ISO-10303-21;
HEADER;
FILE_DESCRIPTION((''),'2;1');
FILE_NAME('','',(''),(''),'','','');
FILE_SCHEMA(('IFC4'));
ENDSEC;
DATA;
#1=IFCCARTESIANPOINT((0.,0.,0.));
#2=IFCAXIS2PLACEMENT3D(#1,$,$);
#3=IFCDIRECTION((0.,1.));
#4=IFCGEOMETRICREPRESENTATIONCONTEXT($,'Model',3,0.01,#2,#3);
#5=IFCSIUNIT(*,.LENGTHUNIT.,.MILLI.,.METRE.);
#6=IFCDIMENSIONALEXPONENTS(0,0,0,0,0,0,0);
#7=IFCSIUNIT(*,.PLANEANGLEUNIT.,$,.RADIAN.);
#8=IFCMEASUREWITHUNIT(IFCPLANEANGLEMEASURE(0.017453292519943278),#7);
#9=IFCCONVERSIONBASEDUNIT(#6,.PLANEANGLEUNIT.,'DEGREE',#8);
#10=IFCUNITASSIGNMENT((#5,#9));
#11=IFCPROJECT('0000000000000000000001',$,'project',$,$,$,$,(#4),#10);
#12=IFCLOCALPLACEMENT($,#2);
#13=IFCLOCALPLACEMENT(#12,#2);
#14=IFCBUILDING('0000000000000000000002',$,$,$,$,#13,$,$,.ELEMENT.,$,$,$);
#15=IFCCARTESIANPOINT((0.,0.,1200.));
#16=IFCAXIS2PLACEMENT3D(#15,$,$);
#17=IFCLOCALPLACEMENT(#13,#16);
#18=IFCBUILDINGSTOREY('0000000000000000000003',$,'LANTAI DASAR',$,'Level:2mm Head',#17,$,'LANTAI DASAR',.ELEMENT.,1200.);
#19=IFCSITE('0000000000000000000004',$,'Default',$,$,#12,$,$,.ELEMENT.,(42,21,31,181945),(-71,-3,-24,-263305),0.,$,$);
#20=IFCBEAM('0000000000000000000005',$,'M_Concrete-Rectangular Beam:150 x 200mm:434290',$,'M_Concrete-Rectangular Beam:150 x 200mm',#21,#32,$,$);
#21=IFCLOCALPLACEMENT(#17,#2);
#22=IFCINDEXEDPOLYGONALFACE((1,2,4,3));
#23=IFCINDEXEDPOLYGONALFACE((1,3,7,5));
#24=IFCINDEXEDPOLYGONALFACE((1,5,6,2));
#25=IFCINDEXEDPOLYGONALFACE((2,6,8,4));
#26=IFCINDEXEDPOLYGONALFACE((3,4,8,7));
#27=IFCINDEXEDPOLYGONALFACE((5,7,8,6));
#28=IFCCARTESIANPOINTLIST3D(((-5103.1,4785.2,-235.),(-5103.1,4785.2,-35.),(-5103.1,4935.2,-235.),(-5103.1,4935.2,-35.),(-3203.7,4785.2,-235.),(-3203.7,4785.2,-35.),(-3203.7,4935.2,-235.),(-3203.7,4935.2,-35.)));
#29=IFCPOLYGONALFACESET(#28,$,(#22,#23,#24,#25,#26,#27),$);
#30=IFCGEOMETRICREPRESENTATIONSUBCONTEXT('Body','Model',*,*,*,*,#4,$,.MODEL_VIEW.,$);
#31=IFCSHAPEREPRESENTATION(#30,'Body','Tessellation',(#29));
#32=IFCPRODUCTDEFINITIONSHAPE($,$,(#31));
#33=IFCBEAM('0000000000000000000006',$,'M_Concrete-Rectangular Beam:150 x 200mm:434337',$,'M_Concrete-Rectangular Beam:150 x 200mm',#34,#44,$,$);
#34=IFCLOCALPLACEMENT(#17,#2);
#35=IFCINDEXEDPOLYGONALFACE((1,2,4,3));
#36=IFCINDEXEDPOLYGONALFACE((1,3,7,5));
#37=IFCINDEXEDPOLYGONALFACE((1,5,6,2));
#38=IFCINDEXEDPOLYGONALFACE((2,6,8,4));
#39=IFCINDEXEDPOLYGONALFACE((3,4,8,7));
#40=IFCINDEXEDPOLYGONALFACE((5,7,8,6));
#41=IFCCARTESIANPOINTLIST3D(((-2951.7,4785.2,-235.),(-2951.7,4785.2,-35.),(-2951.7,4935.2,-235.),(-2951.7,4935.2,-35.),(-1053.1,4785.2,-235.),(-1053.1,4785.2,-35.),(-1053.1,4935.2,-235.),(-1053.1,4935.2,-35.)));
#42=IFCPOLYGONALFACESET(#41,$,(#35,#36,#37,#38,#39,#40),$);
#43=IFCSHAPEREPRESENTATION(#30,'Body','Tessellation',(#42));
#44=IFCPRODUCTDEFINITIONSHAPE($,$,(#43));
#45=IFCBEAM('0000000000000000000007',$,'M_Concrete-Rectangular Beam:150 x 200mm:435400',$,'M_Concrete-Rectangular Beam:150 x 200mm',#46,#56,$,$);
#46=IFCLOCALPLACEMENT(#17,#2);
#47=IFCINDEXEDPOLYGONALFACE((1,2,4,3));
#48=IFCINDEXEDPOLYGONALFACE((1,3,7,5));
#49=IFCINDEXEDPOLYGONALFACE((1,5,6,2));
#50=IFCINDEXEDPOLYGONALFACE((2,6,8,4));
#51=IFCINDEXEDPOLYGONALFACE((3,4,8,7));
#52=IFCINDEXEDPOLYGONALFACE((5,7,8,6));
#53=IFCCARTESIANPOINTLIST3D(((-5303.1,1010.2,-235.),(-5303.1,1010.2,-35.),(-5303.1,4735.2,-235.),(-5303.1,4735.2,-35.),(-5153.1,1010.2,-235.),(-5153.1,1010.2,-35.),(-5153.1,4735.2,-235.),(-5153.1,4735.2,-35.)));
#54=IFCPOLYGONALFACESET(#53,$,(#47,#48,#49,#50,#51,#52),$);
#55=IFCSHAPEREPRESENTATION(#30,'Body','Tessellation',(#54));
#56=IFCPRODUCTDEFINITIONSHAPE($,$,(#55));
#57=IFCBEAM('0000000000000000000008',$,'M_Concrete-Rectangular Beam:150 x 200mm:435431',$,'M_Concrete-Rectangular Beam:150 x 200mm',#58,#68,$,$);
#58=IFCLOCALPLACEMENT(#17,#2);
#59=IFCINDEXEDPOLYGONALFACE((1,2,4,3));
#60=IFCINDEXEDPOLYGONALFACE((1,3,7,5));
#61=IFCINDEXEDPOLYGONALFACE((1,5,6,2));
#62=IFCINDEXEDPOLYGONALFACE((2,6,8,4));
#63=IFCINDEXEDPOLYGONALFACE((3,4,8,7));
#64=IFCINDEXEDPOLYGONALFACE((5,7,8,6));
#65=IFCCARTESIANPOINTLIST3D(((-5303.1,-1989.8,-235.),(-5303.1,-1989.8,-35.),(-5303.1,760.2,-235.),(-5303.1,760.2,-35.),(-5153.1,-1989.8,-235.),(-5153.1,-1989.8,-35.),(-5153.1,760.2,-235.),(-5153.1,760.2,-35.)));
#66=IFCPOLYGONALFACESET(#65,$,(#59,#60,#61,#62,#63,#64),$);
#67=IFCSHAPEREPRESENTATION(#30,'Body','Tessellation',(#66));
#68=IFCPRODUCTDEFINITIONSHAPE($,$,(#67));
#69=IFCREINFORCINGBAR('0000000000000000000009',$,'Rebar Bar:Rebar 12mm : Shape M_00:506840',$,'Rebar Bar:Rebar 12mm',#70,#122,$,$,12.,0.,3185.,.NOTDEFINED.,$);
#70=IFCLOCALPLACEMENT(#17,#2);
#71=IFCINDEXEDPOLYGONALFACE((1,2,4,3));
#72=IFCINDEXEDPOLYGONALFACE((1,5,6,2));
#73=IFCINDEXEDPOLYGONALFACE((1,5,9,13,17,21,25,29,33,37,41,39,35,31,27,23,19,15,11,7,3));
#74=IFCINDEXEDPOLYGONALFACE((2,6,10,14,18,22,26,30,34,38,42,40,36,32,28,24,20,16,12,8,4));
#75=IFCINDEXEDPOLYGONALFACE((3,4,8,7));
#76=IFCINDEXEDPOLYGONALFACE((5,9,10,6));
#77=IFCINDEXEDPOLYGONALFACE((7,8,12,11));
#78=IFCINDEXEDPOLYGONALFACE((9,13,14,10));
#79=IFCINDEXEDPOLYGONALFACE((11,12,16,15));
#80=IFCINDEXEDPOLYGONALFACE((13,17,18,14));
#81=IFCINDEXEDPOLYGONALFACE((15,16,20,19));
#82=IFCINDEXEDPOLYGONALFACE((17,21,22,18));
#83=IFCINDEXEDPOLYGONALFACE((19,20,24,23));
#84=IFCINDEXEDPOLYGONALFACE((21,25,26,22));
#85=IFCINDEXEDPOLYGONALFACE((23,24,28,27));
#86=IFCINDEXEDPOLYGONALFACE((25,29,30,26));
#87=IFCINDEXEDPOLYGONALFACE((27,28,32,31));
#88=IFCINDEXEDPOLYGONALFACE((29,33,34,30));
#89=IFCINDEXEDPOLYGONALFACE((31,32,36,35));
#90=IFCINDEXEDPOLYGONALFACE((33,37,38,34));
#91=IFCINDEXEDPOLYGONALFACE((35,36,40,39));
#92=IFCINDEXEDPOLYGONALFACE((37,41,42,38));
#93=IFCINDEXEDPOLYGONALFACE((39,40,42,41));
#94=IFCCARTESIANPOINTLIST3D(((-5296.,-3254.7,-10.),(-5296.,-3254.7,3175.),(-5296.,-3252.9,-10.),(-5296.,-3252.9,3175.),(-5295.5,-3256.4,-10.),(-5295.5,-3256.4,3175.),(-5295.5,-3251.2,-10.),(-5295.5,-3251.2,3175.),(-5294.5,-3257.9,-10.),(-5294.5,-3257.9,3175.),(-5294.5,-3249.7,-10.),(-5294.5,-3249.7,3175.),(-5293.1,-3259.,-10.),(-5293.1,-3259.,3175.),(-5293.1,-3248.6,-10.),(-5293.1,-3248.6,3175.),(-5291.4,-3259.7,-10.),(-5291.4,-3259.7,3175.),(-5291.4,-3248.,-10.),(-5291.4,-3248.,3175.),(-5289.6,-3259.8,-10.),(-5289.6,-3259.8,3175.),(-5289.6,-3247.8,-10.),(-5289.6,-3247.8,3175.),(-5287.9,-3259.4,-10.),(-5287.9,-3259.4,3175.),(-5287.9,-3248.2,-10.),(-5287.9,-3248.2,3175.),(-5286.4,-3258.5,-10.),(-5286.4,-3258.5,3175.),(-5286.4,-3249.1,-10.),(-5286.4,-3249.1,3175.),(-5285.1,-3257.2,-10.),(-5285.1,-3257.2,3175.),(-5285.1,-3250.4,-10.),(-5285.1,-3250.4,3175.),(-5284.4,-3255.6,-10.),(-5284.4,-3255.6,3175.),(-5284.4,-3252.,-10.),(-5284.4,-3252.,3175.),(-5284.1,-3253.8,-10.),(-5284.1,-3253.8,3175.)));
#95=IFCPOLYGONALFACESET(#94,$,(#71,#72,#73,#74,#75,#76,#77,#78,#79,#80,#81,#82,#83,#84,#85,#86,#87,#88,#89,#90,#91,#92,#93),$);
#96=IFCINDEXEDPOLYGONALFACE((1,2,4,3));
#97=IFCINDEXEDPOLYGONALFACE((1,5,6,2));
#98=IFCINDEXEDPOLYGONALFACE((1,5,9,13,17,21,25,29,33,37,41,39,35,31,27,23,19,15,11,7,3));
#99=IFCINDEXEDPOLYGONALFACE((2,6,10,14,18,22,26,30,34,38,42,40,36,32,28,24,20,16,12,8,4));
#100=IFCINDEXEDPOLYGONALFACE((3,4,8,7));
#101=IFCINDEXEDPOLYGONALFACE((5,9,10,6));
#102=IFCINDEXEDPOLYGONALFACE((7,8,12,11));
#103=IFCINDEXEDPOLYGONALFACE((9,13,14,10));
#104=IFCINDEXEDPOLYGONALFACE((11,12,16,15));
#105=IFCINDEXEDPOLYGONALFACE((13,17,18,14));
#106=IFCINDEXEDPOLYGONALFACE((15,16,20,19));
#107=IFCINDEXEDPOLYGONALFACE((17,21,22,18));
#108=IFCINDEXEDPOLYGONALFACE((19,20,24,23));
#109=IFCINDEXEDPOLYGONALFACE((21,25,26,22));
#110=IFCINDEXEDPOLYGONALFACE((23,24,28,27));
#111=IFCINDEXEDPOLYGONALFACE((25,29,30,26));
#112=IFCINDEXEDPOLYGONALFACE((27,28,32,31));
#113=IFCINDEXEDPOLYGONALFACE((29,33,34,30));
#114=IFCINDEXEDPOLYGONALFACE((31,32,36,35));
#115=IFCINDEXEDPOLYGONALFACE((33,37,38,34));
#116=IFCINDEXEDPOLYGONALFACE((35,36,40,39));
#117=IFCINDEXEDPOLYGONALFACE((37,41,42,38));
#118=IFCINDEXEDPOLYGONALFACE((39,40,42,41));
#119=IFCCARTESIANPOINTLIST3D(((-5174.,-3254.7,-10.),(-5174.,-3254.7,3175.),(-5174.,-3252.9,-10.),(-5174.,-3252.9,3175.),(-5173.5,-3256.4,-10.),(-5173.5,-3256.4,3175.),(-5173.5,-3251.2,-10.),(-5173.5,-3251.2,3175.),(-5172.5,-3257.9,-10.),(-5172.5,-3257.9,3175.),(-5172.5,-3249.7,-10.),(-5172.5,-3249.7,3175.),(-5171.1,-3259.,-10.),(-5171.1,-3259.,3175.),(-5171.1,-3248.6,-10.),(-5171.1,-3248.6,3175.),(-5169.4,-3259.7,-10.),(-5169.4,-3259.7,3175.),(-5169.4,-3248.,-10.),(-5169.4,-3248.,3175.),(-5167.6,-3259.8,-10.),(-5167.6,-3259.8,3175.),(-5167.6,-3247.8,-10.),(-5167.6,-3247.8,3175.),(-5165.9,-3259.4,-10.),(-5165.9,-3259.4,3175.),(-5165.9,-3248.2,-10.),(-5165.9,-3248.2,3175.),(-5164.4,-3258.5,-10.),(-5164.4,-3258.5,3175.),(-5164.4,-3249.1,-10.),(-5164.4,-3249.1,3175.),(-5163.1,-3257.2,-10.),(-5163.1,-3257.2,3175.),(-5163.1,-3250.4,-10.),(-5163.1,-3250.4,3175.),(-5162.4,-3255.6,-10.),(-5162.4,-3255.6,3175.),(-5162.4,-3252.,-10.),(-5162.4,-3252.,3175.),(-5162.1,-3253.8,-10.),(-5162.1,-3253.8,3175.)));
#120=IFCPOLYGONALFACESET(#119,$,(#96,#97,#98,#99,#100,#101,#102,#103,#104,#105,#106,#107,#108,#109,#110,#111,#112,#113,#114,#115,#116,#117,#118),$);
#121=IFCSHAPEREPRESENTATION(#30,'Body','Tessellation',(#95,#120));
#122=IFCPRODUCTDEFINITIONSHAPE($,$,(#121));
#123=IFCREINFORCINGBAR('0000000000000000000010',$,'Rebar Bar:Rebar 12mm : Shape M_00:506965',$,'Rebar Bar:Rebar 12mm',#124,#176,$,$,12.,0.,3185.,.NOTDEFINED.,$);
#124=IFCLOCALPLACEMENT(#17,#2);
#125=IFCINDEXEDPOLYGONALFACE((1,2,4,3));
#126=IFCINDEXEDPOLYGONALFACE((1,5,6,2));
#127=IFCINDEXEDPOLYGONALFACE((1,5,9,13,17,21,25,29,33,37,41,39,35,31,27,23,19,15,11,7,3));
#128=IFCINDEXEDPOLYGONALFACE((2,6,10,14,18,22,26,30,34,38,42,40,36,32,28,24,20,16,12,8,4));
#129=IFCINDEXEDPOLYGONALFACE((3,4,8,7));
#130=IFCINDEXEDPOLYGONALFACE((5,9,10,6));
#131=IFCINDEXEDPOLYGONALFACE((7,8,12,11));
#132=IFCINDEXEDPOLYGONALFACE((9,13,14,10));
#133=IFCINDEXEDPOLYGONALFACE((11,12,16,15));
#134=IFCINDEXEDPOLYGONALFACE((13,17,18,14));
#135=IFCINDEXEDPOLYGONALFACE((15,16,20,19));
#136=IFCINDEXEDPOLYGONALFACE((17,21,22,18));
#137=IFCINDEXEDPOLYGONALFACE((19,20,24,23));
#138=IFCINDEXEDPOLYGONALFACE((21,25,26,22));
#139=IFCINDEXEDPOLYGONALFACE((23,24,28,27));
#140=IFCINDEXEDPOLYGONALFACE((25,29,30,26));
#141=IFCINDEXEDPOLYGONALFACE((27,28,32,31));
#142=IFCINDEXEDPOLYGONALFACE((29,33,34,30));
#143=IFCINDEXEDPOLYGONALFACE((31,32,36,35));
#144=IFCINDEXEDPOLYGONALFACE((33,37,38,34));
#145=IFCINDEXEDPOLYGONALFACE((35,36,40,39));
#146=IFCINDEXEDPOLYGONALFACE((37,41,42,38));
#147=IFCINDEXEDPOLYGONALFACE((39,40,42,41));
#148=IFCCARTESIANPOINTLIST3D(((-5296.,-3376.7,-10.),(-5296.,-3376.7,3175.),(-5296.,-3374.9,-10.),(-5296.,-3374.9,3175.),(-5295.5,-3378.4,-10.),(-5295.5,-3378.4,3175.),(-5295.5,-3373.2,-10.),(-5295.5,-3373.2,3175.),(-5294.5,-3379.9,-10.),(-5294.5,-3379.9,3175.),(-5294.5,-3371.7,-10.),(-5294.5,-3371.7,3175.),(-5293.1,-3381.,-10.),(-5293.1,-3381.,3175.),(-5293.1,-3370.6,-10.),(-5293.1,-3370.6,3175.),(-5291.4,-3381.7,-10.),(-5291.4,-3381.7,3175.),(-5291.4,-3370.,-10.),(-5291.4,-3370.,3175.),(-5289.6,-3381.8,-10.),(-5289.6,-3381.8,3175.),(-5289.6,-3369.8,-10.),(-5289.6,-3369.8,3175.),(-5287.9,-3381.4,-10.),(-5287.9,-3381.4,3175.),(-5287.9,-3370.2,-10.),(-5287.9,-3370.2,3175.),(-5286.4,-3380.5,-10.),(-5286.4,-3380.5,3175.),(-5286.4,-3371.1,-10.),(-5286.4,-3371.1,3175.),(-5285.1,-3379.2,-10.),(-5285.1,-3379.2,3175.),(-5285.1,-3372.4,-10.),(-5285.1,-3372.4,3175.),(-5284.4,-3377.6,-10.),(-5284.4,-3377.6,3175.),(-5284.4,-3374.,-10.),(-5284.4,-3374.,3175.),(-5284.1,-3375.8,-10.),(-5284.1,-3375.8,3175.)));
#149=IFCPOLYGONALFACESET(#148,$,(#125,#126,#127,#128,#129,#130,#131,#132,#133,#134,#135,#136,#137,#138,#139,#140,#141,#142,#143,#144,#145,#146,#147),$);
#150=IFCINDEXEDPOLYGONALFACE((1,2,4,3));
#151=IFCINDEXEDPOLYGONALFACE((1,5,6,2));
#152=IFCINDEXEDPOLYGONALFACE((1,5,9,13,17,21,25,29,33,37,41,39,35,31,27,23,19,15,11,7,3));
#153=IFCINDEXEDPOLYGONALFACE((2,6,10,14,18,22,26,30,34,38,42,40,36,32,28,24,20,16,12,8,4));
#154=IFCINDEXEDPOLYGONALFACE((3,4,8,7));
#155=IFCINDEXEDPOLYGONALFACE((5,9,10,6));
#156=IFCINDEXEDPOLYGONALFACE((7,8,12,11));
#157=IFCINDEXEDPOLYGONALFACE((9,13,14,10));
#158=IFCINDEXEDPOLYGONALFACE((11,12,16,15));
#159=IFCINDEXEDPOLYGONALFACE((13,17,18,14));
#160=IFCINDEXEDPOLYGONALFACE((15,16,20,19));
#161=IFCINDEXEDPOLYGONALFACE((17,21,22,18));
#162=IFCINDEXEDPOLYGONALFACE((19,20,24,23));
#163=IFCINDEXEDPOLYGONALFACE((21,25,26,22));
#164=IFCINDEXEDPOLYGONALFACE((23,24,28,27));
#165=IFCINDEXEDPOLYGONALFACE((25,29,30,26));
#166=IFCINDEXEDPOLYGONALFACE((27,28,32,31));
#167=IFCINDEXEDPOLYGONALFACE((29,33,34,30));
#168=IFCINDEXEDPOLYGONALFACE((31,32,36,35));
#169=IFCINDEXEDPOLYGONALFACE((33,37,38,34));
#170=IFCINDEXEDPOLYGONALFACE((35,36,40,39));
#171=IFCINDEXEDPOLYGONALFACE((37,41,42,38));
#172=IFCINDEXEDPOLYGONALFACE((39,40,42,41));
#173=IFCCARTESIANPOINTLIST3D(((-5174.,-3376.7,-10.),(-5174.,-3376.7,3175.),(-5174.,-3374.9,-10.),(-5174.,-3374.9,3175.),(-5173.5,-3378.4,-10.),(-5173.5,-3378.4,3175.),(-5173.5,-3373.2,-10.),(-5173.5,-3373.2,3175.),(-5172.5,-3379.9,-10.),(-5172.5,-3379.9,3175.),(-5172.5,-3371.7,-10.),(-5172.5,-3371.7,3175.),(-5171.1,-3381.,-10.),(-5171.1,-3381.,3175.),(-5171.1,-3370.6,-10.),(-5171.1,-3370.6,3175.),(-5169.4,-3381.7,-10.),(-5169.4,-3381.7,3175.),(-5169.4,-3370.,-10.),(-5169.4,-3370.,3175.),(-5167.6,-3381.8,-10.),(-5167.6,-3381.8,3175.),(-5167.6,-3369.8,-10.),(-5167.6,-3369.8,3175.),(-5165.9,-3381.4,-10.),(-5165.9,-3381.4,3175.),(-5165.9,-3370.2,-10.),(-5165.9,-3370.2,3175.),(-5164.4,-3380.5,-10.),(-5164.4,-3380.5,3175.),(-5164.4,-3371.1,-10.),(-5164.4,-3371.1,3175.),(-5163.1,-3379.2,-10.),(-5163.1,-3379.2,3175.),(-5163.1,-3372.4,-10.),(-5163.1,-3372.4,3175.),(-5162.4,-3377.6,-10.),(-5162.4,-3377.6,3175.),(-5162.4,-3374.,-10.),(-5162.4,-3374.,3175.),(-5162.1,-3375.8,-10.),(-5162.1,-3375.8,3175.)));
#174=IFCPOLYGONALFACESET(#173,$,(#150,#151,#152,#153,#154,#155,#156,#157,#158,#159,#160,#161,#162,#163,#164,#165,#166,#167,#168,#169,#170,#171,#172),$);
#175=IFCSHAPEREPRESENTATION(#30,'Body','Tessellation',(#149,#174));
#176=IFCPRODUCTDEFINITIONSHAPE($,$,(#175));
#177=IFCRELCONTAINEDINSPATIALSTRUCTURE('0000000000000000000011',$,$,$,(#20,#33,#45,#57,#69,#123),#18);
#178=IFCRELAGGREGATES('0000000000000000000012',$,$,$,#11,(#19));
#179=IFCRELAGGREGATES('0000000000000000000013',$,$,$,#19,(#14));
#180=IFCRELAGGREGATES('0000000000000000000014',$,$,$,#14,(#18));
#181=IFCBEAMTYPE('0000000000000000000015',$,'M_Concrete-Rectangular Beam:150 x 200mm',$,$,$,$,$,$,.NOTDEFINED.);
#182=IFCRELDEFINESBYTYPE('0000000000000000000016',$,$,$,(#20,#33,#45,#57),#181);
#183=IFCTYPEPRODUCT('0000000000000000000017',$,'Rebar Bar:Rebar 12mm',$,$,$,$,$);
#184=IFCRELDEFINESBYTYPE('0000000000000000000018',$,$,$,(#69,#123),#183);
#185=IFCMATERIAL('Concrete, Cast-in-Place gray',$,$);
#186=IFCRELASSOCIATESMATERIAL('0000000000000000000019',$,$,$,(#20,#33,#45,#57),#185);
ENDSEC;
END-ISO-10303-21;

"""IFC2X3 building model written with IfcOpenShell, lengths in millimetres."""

from ifc_helpers import new_model, entity, si_unit, converted_unit, direction, frame, frame_2d, origin, place, context, subcontext, project, spatial, rectangle, extrude, material, type_object, element, save


model = new_model("IFC2X3")

# Units and contexts
model_context = context("Model", 3, precision=0.01, world=origin(), true_north=direction((0.0, 1.0)))
body_context = subcontext(model_context, "Body", "Model", "MODEL_VIEW")
ifc_project = project(units=[si_unit("LENGTHUNIT", "METRE", prefix="MILLI"), converted_unit("PLANEANGLEUNIT", "DEGREE", entity("IfcPlaneAngleMeasure", 0.017453292519943278), si_unit("PLANEANGLEUNIT", "RADIAN"), dimensions=[0, 0, 0, 0, 0, 0, 0])], contexts=[model_context])

# Site, building, storey
site_placement = place(None, origin())
site = spatial("IfcSite", under=ifc_project, at=site_placement, Name="Default", CompositionType="ELEMENT", RefLatitude=(42, 21, 31, 181945), RefLongitude=(-71, -3, -24, -263305), RefElevation=0.0)
building_placement = place(site_placement, origin())
building = spatial("IfcBuilding", under=site, at=building_placement, CompositionType="ELEMENT")
storey_placement = place(building_placement, frame((0.0, 0.0, 1200.0)))
storey = spatial("IfcBuildingStorey", under=building, at=storey_placement, Name="LANTAI DASAR", ObjectType="Level:2mm Head", LongName="LANTAI DASAR", CompositionType="ELEMENT", Elevation=1200.0)

# Shared definitions
ifc_material_1 = material(Name="Concrete, Cast-in-Place gray")

# Beams
beam_type = type_object("IfcBeamType", Name="M_Concrete-Rectangular Beam:150 x 200mm", PredefinedType="NOTDEFINED")
beam_1_placement = place(storey_placement, frame((-5103.1, 4860.2, -35.0)))
element("IfcBeam", 1, at=beam_1_placement, inside=storey, type_object=beam_type, material=ifc_material_1, Name="M_Concrete-Rectangular Beam:150 x 200mm:434290", ObjectType="M_Concrete-Rectangular Beam:150 x 200mm", context=body_context, shape_type="SweptSolid", body=[
    extrude(rectangle(XDim=200.0, YDim=150.0, at=frame_2d((0.0, 0.0), x_axis=(1.0, 0.0))), frame((0.0, 0.0, -100.0), z_axis=(1.0, 0.0, 0.0), x_axis=(0.0, 0.0, -1.0)), (0.0, 0.0, 1.0), 1899.4),
])
beam_2_placement = place(storey_placement, frame((-2953.7, 4860.2, -35.0)))
element("IfcBeam", 2, at=beam_2_placement, inside=storey, type_object=beam_type, material=ifc_material_1, Name="M_Concrete-Rectangular Beam:150 x 200mm:434337", ObjectType="M_Concrete-Rectangular Beam:150 x 200mm", context=body_context, shape_type="SweptSolid", body=[
    extrude(rectangle(XDim=200.0, YDim=150.0, at=frame_2d((0.0, 0.0), x_axis=(1.0, 0.0))), frame((2.0, 0.0, -100.0), z_axis=(1.0, 0.0, 0.0), x_axis=(0.0, 0.0, -1.0)), (0.0, 0.0, 1.0), 1898.6),
])
beam_3_placement = place(storey_placement, frame((-5228.1, 4735.2, -35.0), z_axis=(0.0, 0.0, 1.0), x_axis=(0.0, -1.0, 0.0)))
element("IfcBeam", 3, at=beam_3_placement, inside=storey, type_object=beam_type, material=ifc_material_1, Name="M_Concrete-Rectangular Beam:150 x 200mm:435400", ObjectType="M_Concrete-Rectangular Beam:150 x 200mm", context=body_context, shape_type="SweptSolid", body=[
    extrude(rectangle(XDim=200.0, YDim=150.0, at=frame_2d((0.0, 0.0), x_axis=(1.0, 0.0))), frame((0.0, 0.0, -100.0), z_axis=(1.0, 0.0, 0.0), x_axis=(0.0, 0.0, -1.0)), (0.0, 0.0, 1.0), 3725.0),
])
beam_4_placement = place(storey_placement, frame((-5228.1, 885.2, -35.0), z_axis=(0.0, 0.0, 1.0), x_axis=(0.0, -1.0, 0.0)))
element("IfcBeam", 4, at=beam_4_placement, inside=storey, type_object=beam_type, material=ifc_material_1, Name="M_Concrete-Rectangular Beam:150 x 200mm:435431", ObjectType="M_Concrete-Rectangular Beam:150 x 200mm", context=body_context, shape_type="SweptSolid", body=[
    extrude(rectangle(XDim=200.0, YDim=150.0, at=frame_2d((0.0, 0.0), x_axis=(1.0, 0.0))), frame((125.0, 0.0, -100.0), z_axis=(1.0, 0.0, 0.0), x_axis=(0.0, 0.0, -1.0)), (0.0, 0.0, 1.0), 2750.0),
])

# Reinforcing bars
type_product_1 = type_object("IfcTypeProduct", Name="Rebar Bar:Rebar 12mm")
reinforcing_bar_1_placement = place(storey_placement, origin())
element("IfcReinforcingBar", 5, at=reinforcing_bar_1_placement, inside=storey, type_object=type_product_1, Name="Rebar Bar:Rebar 12mm : Shape M_00:506840", ObjectType="Rebar Bar:Rebar 12mm", BarLength=3185.0, BarRole="NOTDEFINED", CrossSectionArea=0.0, NominalDiameter=12.0, context=body_context, shape_type="AdvancedSweptSolid", body=[
    entity("IfcSweptDiskSolid", entity("IfcCompositeCurve", [entity("IfcCompositeCurveSegment", "CONTINUOUS", True, entity("IfcPolyline", [entity("IfcCartesianPoint", [-5290.1, -3253.8, -10.0]), entity("IfcCartesianPoint", [-5290.1, -3253.8, 3175.0])]))], False), 6.0, None, 0.0, 1.0),
    entity("IfcSweptDiskSolid", entity("IfcCompositeCurve", [entity("IfcCompositeCurveSegment", "CONTINUOUS", True, entity("IfcPolyline", [entity("IfcCartesianPoint", [-5168.1, -3253.8, -10.0]), entity("IfcCartesianPoint", [-5168.1, -3253.8, 3175.0])]))], False), 6.0, None, 0.0, 1.0),
])
reinforcing_bar_2_placement = place(storey_placement, origin())
element("IfcReinforcingBar", 6, at=reinforcing_bar_2_placement, inside=storey, type_object=type_product_1, Name="Rebar Bar:Rebar 12mm : Shape M_00:506965", ObjectType="Rebar Bar:Rebar 12mm", BarLength=3185.0, BarRole="NOTDEFINED", CrossSectionArea=0.0, NominalDiameter=12.0, context=body_context, shape_type="AdvancedSweptSolid", body=[
    entity("IfcSweptDiskSolid", entity("IfcCompositeCurve", [entity("IfcCompositeCurveSegment", "CONTINUOUS", True, entity("IfcPolyline", [entity("IfcCartesianPoint", [-5290.1, -3375.8, -10.0]), entity("IfcCartesianPoint", [-5290.1, -3375.8, 3175.0])]))], False), 6.0, None, 0.0, 1.0),
    entity("IfcSweptDiskSolid", entity("IfcCompositeCurve", [entity("IfcCompositeCurveSegment", "CONTINUOUS", True, entity("IfcPolyline", [entity("IfcCartesianPoint", [-5168.1, -3375.8, -10.0]), entity("IfcCartesianPoint", [-5168.1, -3375.8, 3175.0])]))], False), 6.0, None, 0.0, 1.0),
])

save(model, "model.ifc")
